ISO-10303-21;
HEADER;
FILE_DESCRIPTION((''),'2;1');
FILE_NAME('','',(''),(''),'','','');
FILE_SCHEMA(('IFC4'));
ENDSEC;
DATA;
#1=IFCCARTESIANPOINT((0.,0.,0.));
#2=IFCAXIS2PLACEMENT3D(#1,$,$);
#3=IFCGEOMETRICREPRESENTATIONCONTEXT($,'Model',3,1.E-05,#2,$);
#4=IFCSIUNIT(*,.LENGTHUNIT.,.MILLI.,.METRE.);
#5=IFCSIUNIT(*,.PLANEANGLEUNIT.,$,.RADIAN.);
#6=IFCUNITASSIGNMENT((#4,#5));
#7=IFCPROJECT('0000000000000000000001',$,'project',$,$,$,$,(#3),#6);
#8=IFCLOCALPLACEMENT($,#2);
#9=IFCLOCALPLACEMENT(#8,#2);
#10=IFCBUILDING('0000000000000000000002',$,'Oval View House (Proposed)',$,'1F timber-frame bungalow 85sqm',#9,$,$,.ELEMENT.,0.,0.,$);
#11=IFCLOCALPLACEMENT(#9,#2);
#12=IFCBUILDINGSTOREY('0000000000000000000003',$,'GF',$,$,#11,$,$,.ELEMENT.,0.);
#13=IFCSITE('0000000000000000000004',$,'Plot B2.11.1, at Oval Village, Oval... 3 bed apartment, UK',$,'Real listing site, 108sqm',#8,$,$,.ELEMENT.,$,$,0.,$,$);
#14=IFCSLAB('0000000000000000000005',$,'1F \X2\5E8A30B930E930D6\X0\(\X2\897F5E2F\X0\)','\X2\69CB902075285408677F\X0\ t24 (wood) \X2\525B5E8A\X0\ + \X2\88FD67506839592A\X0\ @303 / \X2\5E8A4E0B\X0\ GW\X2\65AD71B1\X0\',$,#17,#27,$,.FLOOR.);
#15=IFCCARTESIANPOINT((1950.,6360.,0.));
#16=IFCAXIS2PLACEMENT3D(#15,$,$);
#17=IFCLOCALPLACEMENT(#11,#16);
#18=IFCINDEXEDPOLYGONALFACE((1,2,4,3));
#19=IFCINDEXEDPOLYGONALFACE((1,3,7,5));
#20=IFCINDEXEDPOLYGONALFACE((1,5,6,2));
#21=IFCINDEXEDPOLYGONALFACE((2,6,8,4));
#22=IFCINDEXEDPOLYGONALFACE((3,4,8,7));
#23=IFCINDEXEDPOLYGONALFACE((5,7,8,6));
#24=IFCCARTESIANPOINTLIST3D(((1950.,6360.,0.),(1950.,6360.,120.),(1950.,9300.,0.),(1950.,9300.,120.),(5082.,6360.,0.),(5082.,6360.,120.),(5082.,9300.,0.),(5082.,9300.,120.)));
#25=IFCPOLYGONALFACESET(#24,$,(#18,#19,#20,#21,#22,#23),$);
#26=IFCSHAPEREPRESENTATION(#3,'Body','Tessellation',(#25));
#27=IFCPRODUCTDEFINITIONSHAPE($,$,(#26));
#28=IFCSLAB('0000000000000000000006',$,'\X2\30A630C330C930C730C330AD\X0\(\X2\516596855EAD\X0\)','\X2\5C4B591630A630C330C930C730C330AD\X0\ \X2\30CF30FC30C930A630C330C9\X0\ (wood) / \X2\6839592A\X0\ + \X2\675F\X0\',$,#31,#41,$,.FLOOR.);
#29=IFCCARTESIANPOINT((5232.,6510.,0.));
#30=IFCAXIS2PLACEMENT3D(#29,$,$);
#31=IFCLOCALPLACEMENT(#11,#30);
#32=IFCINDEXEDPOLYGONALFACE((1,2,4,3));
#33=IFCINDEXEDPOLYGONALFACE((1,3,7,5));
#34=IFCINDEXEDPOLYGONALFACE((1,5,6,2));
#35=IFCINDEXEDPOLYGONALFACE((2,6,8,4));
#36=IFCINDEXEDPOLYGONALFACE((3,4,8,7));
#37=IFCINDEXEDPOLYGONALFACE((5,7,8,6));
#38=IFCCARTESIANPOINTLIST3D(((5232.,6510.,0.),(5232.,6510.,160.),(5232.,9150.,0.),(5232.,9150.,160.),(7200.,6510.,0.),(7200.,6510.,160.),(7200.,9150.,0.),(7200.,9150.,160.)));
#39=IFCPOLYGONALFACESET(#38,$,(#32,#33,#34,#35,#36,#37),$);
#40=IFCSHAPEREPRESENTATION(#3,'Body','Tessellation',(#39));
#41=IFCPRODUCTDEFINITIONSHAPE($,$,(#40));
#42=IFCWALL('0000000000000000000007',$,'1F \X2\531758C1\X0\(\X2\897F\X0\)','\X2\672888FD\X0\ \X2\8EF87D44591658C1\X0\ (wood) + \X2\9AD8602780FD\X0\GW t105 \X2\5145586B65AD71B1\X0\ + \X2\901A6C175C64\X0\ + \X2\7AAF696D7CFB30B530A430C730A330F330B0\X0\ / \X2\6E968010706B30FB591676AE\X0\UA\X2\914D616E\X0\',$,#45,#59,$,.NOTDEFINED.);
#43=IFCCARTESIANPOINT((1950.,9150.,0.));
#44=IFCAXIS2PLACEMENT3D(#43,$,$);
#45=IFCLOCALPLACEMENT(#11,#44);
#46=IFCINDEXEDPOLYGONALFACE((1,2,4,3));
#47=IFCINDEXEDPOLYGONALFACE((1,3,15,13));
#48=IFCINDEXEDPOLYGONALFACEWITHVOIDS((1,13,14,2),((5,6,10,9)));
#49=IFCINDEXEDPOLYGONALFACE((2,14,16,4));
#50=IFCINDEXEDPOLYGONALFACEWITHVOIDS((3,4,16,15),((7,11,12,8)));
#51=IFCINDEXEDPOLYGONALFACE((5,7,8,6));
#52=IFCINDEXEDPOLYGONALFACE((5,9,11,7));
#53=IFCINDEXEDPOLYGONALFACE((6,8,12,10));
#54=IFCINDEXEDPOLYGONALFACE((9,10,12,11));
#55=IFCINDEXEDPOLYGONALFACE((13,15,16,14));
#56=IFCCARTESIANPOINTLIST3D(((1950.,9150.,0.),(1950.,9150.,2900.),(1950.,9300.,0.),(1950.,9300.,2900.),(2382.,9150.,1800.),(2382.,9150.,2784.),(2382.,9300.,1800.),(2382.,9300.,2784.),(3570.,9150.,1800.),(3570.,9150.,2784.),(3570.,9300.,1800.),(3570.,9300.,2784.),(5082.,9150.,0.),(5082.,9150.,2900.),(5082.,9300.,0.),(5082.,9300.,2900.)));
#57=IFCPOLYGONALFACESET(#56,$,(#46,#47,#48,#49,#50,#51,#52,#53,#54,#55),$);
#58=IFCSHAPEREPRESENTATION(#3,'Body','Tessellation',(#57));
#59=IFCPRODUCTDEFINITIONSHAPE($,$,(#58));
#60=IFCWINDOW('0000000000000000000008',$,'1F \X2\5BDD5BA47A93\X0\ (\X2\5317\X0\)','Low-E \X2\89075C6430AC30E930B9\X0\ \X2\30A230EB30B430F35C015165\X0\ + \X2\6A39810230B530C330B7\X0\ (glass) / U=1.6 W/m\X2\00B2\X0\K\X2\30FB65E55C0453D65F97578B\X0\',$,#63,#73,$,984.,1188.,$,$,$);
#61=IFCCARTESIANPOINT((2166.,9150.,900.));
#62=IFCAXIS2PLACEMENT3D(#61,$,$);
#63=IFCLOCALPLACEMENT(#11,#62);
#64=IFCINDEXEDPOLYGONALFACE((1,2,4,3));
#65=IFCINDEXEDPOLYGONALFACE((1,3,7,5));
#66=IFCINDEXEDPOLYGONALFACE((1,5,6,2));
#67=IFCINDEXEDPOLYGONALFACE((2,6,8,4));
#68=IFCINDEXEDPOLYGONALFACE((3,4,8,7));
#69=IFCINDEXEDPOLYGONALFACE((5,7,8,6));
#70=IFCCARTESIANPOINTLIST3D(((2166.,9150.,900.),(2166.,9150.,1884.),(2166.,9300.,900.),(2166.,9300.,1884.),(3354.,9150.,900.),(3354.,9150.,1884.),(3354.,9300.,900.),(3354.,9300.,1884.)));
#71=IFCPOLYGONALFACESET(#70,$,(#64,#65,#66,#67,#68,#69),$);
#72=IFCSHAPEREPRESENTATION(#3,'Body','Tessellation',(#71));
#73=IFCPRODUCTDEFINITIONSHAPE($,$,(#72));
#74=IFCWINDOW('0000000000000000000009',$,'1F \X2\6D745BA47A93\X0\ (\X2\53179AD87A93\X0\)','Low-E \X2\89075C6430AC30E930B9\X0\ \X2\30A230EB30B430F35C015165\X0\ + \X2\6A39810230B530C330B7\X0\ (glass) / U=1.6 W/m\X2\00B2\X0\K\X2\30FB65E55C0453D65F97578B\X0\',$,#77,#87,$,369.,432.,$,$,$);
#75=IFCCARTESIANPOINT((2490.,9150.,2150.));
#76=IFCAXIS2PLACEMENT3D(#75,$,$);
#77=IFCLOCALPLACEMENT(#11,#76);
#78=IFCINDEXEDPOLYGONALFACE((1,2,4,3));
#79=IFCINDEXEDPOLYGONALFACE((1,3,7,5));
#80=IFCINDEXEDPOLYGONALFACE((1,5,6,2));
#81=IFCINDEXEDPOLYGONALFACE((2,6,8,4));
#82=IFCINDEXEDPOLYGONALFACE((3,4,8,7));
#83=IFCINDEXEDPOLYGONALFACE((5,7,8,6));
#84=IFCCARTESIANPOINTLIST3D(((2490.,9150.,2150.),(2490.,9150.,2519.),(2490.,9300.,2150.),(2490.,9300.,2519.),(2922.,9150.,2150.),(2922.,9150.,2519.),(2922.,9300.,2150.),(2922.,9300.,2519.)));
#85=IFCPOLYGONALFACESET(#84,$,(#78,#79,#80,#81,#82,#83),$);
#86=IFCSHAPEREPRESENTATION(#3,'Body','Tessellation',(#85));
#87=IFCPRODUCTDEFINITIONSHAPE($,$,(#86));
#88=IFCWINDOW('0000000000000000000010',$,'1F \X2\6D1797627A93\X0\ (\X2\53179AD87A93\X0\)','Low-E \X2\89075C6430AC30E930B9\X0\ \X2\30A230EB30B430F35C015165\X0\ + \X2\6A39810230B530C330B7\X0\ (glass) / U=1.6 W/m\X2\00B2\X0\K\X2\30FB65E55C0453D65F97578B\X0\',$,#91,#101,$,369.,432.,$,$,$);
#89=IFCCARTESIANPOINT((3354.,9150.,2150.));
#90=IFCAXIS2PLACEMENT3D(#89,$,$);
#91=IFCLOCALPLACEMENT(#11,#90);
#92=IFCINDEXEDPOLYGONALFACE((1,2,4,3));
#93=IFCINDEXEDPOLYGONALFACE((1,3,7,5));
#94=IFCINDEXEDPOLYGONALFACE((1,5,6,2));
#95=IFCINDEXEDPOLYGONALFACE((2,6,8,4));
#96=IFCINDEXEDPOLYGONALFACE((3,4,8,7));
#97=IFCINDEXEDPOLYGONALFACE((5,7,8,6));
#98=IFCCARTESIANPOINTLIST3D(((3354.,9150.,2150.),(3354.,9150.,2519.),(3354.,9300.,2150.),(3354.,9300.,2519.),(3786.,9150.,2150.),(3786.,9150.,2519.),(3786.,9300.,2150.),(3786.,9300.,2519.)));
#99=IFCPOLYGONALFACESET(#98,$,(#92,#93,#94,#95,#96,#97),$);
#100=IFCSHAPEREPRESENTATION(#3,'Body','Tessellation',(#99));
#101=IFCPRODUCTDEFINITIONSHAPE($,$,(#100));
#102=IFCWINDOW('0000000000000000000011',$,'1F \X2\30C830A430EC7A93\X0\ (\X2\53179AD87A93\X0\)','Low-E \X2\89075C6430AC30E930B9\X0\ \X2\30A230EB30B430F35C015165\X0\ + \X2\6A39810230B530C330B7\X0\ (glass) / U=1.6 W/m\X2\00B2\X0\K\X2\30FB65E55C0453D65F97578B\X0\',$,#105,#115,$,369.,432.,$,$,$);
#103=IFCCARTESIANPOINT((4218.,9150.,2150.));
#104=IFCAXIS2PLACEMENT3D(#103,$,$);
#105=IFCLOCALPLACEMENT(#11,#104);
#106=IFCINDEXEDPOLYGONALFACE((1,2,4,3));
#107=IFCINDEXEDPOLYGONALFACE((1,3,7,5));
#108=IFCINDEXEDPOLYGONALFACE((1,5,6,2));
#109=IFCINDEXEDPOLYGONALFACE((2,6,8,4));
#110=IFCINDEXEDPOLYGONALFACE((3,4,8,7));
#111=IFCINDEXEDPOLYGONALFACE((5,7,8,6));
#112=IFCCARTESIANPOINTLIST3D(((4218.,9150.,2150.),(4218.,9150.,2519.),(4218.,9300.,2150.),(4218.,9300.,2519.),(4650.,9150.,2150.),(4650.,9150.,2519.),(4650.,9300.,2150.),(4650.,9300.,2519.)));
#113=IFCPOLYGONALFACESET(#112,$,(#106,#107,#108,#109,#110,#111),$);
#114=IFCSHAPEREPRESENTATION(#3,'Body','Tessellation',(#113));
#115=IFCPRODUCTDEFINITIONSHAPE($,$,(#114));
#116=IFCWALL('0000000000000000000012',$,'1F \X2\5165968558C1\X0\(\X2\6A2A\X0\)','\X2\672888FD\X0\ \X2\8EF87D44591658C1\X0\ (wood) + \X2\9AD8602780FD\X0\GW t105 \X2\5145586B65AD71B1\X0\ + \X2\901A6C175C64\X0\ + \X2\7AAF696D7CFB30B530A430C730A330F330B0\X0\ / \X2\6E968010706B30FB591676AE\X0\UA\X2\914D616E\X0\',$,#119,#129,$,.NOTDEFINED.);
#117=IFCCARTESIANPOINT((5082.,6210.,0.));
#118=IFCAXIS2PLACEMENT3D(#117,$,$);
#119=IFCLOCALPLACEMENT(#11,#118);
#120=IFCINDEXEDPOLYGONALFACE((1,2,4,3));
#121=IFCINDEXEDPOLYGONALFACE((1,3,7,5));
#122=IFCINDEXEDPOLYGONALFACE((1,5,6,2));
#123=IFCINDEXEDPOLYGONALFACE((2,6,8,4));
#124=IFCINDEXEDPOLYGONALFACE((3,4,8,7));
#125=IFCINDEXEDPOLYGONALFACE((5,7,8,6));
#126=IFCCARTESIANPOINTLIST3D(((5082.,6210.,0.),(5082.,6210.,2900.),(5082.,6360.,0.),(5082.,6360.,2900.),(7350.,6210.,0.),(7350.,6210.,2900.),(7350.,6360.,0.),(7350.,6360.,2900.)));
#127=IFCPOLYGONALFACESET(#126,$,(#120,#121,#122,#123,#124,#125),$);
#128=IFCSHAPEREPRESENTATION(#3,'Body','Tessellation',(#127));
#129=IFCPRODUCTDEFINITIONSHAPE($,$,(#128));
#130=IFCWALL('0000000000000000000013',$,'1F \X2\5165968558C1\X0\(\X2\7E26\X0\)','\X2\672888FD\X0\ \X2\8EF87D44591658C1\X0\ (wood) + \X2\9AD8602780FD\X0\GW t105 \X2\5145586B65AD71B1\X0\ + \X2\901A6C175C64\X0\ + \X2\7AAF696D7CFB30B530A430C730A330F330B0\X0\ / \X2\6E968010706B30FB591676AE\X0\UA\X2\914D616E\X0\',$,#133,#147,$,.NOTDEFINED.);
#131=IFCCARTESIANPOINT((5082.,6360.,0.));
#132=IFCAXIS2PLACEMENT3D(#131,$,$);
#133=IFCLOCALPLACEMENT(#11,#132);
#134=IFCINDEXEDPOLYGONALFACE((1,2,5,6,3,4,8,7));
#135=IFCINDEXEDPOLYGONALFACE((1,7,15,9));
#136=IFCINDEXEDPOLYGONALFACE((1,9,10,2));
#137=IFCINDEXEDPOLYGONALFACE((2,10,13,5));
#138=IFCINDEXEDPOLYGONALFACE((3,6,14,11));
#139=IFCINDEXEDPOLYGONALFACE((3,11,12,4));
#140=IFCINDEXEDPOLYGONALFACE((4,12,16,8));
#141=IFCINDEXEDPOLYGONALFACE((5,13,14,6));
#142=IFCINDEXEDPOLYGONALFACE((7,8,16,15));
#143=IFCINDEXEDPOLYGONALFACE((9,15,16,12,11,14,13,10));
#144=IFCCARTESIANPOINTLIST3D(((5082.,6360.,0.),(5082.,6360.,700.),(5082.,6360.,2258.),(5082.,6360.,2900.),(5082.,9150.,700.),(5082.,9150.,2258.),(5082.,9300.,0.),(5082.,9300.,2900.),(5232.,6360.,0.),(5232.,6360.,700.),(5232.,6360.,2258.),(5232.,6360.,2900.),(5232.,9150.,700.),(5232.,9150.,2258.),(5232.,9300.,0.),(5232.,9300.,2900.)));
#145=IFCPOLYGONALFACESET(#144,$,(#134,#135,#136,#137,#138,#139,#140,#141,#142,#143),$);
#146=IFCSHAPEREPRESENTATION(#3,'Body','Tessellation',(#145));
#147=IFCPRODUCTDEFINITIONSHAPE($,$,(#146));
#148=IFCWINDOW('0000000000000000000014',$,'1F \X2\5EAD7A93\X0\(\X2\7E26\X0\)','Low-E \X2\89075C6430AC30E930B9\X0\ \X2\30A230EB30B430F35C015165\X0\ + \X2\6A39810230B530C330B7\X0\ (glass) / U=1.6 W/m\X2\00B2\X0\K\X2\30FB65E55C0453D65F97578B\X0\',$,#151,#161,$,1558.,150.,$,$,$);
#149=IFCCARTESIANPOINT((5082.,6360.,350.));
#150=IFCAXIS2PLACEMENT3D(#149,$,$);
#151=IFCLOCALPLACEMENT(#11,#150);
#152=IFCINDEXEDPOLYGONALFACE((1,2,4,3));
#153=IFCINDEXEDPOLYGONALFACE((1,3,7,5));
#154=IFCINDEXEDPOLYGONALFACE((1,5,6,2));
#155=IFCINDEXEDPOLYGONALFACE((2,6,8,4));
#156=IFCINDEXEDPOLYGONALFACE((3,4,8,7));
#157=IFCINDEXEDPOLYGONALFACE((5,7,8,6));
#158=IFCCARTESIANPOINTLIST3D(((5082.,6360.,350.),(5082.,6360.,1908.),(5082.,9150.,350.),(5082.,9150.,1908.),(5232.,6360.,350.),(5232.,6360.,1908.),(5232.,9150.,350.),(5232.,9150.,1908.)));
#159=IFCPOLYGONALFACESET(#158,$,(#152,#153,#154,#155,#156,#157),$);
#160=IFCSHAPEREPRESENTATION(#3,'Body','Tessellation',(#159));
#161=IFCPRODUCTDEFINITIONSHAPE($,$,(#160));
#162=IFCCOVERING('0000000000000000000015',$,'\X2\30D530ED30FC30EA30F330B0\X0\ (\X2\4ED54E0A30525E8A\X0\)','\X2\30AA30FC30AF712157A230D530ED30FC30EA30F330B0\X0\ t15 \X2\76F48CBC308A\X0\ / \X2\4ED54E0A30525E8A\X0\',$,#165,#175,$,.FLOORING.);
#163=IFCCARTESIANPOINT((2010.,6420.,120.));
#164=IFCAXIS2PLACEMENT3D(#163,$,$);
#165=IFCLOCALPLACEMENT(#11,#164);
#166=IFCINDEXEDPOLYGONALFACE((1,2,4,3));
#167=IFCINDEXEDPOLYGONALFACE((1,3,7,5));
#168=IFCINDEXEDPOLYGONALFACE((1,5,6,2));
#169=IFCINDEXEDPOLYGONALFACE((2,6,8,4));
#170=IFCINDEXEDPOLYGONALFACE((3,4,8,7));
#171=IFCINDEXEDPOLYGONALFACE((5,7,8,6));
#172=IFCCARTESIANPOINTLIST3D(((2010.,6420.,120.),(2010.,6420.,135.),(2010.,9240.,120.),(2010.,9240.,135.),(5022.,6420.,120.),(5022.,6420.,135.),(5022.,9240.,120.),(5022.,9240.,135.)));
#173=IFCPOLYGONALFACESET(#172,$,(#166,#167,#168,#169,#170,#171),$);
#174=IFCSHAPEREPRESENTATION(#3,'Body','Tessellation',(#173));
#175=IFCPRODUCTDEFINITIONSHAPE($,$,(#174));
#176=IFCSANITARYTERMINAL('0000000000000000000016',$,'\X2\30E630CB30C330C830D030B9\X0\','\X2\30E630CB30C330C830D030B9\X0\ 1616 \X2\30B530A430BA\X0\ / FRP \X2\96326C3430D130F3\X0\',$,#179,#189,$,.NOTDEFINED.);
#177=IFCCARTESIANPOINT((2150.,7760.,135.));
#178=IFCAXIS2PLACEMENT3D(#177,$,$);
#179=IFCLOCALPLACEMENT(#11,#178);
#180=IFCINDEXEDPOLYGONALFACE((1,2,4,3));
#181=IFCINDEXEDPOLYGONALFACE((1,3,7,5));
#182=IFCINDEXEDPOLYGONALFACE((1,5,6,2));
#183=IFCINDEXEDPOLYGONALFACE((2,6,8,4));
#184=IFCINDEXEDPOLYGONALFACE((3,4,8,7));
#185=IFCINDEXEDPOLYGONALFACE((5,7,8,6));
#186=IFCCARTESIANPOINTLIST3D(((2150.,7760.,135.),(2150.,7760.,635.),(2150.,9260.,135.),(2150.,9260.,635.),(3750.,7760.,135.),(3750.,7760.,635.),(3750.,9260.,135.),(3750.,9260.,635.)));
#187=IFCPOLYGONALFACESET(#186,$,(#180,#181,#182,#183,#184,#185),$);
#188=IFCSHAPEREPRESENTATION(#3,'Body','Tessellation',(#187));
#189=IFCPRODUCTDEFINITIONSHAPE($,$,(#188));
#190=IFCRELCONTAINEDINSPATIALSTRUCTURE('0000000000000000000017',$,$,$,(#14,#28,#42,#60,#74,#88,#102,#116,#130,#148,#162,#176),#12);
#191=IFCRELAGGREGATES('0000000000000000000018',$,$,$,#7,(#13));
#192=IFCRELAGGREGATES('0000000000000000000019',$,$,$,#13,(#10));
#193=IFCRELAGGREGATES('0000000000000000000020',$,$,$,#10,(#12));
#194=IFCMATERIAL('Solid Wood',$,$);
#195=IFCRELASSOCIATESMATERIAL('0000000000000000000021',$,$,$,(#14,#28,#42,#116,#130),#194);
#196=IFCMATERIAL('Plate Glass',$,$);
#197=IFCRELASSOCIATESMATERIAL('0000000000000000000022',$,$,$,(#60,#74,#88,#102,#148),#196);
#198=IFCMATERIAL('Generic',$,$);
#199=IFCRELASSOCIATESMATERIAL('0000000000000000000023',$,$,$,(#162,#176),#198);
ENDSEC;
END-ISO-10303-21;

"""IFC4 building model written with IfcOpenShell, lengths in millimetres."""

from ifc_helpers import new_model, si_unit, frame, frame_2d, origin, place, context, project, spatial, rectangle, extrude, material, element, fill, save


model = new_model("IFC4")

# Units and contexts
model_context = context("Model", 3, precision=1e-05, world=origin())
ifc_project = project(units=[si_unit("LENGTHUNIT", "METRE", prefix="MILLI"), si_unit("PLANEANGLEUNIT", "RADIAN")], contexts=[model_context])

# Site, building, storey
site_placement = place(None, origin())
site = spatial("IfcSite", under=ifc_project, at=site_placement, Name="Plot B2.11.1, at Oval Village, Oval... 3 bed apartment, UK", ObjectType="Real listing site, 108sqm", CompositionType="ELEMENT", RefElevation=0.0)
building_placement = place(site_placement, origin())
building = spatial("IfcBuilding", under=site, at=building_placement, Name="Oval View House (Proposed)", ObjectType="1F timber-frame bungalow 85sqm", CompositionType="ELEMENT", ElevationOfRefHeight=0.0, ElevationOfTerrain=0.0)
storey_placement = place(building_placement, origin())
storey = spatial("IfcBuildingStorey", under=building, at=storey_placement, Name="GF", CompositionType="ELEMENT", Elevation=0.0)

# Slabs
ifc_material_1 = material(Name="Solid Wood")
slab_1_placement = place(storey_placement, frame((1950.0, 6360.0, 0.0)))
element("IfcSlab", 1, at=slab_1_placement, inside=storey, material=ifc_material_1, Name="1F 床スラブ(西帯)", Description="構造用合板 t24 (wood) 剛床 + 製材根太 @303 / 床下 GW断熱", PredefinedType="FLOOR", context=model_context, shape_type="SweptSolid", body=[
    extrude(rectangle(XDim=3132.0, YDim=2940.0, at=frame_2d((1566.0, 1470.0))), frame((1950.0, 6360.0, 0.0)), (0.0, 0.0, 1.0), 120.0),
])
slab_2_placement = place(storey_placement, frame((5232.0, 6510.0, 0.0)))
element("IfcSlab", 2, at=slab_2_placement, inside=storey, material=ifc_material_1, Name="ウッドデッキ(入隅庭)", Description="屋外ウッドデッキ ハードウッド (wood) / 根太 + 束", PredefinedType="FLOOR", context=model_context, shape_type="SweptSolid", body=[
    extrude(rectangle(XDim=1968.0, YDim=2640.0, at=frame_2d((984.0, 1320.0))), frame((5232.0, 6510.0, 0.0)), (0.0, 0.0, 1.0), 160.0),
])

# Wall, openings, windows
wall_1_placement = place(storey_placement, frame((1950.0, 9150.0, 0.0)))
wall_1 = element("IfcWall", 3, at=wall_1_placement, inside=storey, material=ifc_material_1, Name="1F 北壁(西)", Description="木製 軸組外壁 (wood) + 高性能GW t105 充填断熱 + 通気層 + 窯業系サイディング / 準耐火・外皮UA配慮", PredefinedType="NOTDEFINED", context=model_context, shape_type="SweptSolid", body=[
    extrude(rectangle(XDim=3132.0, YDim=150.0, at=frame_2d((1566.0, 75.0))), frame((1950.0, 9150.0, 0.0)), (0.0, 0.0, 1.0), 2900.0),
])
opening_1_placement = place(storey_placement, frame((2166.0, 9150.0, 900.0)))
opening_1 = element("IfcOpeningElement", 4, at=opening_1_placement, cuts=wall_1, PredefinedType="NOTDEFINED", context=model_context, shape_type="SweptSolid", body=[
    extrude(rectangle(XDim=1188.0, YDim=150.0, at=frame_2d((594.0, 75.0))), frame((2166.0, 9150.0, 900.0)), (0.0, 0.0, 1.0), 984.0),
])
opening_2_placement = place(storey_placement, frame((2490.0, 9150.0, 2150.0)))
opening_2 = element("IfcOpeningElement", 5, at=opening_2_placement, cuts=wall_1, PredefinedType="NOTDEFINED", context=model_context, shape_type="SweptSolid", body=[
    extrude(rectangle(XDim=432.0, YDim=150.0, at=frame_2d((216.0, 75.0))), frame((2490.0, 9150.0, 2150.0)), (0.0, 0.0, 1.0), 369.0),
])
opening_3_placement = place(storey_placement, frame((3354.0, 9150.0, 2150.0)))
opening_3 = element("IfcOpeningElement", 6, at=opening_3_placement, cuts=wall_1, PredefinedType="NOTDEFINED", context=model_context, shape_type="SweptSolid", body=[
    extrude(rectangle(XDim=432.0, YDim=150.0, at=frame_2d((216.0, 75.0))), frame((3354.0, 9150.0, 2150.0)), (0.0, 0.0, 1.0), 369.0),
])
opening_4_placement = place(storey_placement, frame((4218.0, 9150.0, 2150.0)))
opening_4 = element("IfcOpeningElement", 7, at=opening_4_placement, cuts=wall_1, PredefinedType="NOTDEFINED", context=model_context, shape_type="SweptSolid", body=[
    extrude(rectangle(XDim=432.0, YDim=150.0, at=frame_2d((216.0, 75.0))), frame((4218.0, 9150.0, 2150.0)), (0.0, 0.0, 1.0), 369.0),
])
ifc_material_2 = material(Name="Plate Glass")
window_1_placement = place(storey_placement, frame((2166.0, 9150.0, 900.0)))
window_1 = element("IfcWindow", 8, at=window_1_placement, inside=storey, material=ifc_material_2, Name="1F 寝室窓 (北)", Description="Low-E 複層ガラス アルゴン封入 + 樹脂サッシ (glass) / U=1.6 W/m²K・日射取得型", OverallHeight=984.0, OverallWidth=1188.0, context=model_context, shape_type="SweptSolid", body=[
    extrude(rectangle(XDim=1188.0, YDim=150.0, at=frame_2d((594.0, 75.0))), frame((2166.0, 9150.0, 900.0)), (0.0, 0.0, 1.0), 984.0),
])
fill(opening_1, window_1)
window_2_placement = place(storey_placement, frame((2490.0, 9150.0, 2150.0)))
window_2 = element("IfcWindow", 9, at=window_2_placement, inside=storey, material=ifc_material_2, Name="1F 浴室窓 (北高窓)", Description="Low-E 複層ガラス アルゴン封入 + 樹脂サッシ (glass) / U=1.6 W/m²K・日射取得型", OverallHeight=369.0, OverallWidth=432.0, context=model_context, shape_type="SweptSolid", body=[
    extrude(rectangle(XDim=432.0, YDim=150.0, at=frame_2d((216.0, 75.0))), frame((2490.0, 9150.0, 2150.0)), (0.0, 0.0, 1.0), 369.0),
])
fill(opening_2, window_2)
window_3_placement = place(storey_placement, frame((3354.0, 9150.0, 2150.0)))
window_3 = element("IfcWindow", 10, at=window_3_placement, inside=storey, material=ifc_material_2, Name="1F 洗面窓 (北高窓)", Description="Low-E 複層ガラス アルゴン封入 + 樹脂サッシ (glass) / U=1.6 W/m²K・日射取得型", OverallHeight=369.0, OverallWidth=432.0, context=model_context, shape_type="SweptSolid", body=[
    extrude(rectangle(XDim=432.0, YDim=150.0, at=frame_2d((216.0, 75.0))), frame((3354.0, 9150.0, 2150.0)), (0.0, 0.0, 1.0), 369.0),
])
fill(opening_3, window_3)
window_4_placement = place(storey_placement, frame((4218.0, 9150.0, 2150.0)))
window_4 = element("IfcWindow", 11, at=window_4_placement, inside=storey, material=ifc_material_2, Name="1F トイレ窓 (北高窓)", Description="Low-E 複層ガラス アルゴン封入 + 樹脂サッシ (glass) / U=1.6 W/m²K・日射取得型", OverallHeight=369.0, OverallWidth=432.0, context=model_context, shape_type="SweptSolid", body=[
    extrude(rectangle(XDim=432.0, YDim=150.0, at=frame_2d((216.0, 75.0))), frame((4218.0, 9150.0, 2150.0)), (0.0, 0.0, 1.0), 369.0),
])
fill(opening_4, window_4)

# Wall
wall_2_placement = place(storey_placement, frame((5082.0, 6210.0, 0.0)))
element("IfcWall", 12, at=wall_2_placement, inside=storey, material=ifc_material_1, Name="1F 入隅壁(横)", Description="木製 軸組外壁 (wood) + 高性能GW t105 充填断熱 + 通気層 + 窯業系サイディング / 準耐火・外皮UA配慮", PredefinedType="NOTDEFINED", context=model_context, shape_type="SweptSolid", body=[
    extrude(rectangle(XDim=2268.0, YDim=150.0, at=frame_2d((1134.0, 75.0))), frame((5082.0, 6210.0, 0.0)), (0.0, 0.0, 1.0), 2900.0),
])

# Wall, opening, window
wall_3_placement = place(storey_placement, frame((5082.0, 6360.0, 0.0)))
wall_3 = element("IfcWall", 13, at=wall_3_placement, inside=storey, material=ifc_material_1, Name="1F 入隅壁(縦)", Description="木製 軸組外壁 (wood) + 高性能GW t105 充填断熱 + 通気層 + 窯業系サイディング / 準耐火・外皮UA配慮", PredefinedType="NOTDEFINED", context=model_context, shape_type="SweptSolid", body=[
    extrude(rectangle(XDim=150.0, YDim=2940.0, at=frame_2d((75.0, 1470.0))), frame((5082.0, 6360.0, 0.0)), (0.0, 0.0, 1.0), 2900.0),
])
opening_5_placement = place(storey_placement, frame((5082.0, 6360.0, 350.0)))
opening_5 = element("IfcOpeningElement", 14, at=opening_5_placement, cuts=wall_3, PredefinedType="NOTDEFINED", context=model_context, shape_type="SweptSolid", body=[
    extrude(rectangle(XDim=150.0, YDim=2790.0, at=frame_2d((75.0, 1395.0))), frame((5082.0, 6360.0, 350.0)), (0.0, 0.0, 1.0), 1558.0),
])
window_5_placement = place(storey_placement, frame((5082.0, 6360.0, 350.0)))
window_5 = element("IfcWindow", 15, at=window_5_placement, inside=storey, material=ifc_material_2, Name="1F 庭窓(縦)", Description="Low-E 複層ガラス アルゴン封入 + 樹脂サッシ (glass) / U=1.6 W/m²K・日射取得型", OverallHeight=1558.0, OverallWidth=150.0, context=model_context, shape_type="SweptSolid", body=[
    extrude(rectangle(XDim=150.0, YDim=2790.0, at=frame_2d((75.0, 1395.0))), frame((5082.0, 6360.0, 350.0)), (0.0, 0.0, 1.0), 1558.0),
])
fill(opening_5, window_5)

# Covering
ifc_material_3 = material(Name="Generic")
covering_placement = place(storey_placement, frame((2010.0, 6420.0, 120.0)))
element("IfcCovering", 16, at=covering_placement, inside=storey, material=ifc_material_3, Name="フローリング (仕上げ床)", Description="オーク無垢フローリング t15 直貼り / 仕上げ床", PredefinedType="FLOORING", context=model_context, shape_type="SweptSolid", body=[
    extrude(rectangle(XDim=3012.0, YDim=2820.0, at=frame_2d((1506.0, 1410.0))), frame((2010.0, 6420.0, 120.0)), (0.0, 0.0, 1.0), 15.0),
])

# Sanitary terminal
sanitary_terminal_1_placement = place(storey_placement, frame((2150.0, 7760.0, 135.0)))
element("IfcSanitaryTerminal", 17, at=sanitary_terminal_1_placement, inside=storey, material=ifc_material_3, Name="ユニットバス", Description="ユニットバス 1616 サイズ / FRP 防水パン", PredefinedType="NOTDEFINED", context=model_context, shape_type="SweptSolid", body=[
    extrude(rectangle(XDim=1600.0, YDim=1500.0, at=frame_2d((800.0, 750.0))), frame((2150.0, 7760.0, 135.0)), (0.0, 0.0, 1.0), 500.0),
])

save(model, "model.ifc")
